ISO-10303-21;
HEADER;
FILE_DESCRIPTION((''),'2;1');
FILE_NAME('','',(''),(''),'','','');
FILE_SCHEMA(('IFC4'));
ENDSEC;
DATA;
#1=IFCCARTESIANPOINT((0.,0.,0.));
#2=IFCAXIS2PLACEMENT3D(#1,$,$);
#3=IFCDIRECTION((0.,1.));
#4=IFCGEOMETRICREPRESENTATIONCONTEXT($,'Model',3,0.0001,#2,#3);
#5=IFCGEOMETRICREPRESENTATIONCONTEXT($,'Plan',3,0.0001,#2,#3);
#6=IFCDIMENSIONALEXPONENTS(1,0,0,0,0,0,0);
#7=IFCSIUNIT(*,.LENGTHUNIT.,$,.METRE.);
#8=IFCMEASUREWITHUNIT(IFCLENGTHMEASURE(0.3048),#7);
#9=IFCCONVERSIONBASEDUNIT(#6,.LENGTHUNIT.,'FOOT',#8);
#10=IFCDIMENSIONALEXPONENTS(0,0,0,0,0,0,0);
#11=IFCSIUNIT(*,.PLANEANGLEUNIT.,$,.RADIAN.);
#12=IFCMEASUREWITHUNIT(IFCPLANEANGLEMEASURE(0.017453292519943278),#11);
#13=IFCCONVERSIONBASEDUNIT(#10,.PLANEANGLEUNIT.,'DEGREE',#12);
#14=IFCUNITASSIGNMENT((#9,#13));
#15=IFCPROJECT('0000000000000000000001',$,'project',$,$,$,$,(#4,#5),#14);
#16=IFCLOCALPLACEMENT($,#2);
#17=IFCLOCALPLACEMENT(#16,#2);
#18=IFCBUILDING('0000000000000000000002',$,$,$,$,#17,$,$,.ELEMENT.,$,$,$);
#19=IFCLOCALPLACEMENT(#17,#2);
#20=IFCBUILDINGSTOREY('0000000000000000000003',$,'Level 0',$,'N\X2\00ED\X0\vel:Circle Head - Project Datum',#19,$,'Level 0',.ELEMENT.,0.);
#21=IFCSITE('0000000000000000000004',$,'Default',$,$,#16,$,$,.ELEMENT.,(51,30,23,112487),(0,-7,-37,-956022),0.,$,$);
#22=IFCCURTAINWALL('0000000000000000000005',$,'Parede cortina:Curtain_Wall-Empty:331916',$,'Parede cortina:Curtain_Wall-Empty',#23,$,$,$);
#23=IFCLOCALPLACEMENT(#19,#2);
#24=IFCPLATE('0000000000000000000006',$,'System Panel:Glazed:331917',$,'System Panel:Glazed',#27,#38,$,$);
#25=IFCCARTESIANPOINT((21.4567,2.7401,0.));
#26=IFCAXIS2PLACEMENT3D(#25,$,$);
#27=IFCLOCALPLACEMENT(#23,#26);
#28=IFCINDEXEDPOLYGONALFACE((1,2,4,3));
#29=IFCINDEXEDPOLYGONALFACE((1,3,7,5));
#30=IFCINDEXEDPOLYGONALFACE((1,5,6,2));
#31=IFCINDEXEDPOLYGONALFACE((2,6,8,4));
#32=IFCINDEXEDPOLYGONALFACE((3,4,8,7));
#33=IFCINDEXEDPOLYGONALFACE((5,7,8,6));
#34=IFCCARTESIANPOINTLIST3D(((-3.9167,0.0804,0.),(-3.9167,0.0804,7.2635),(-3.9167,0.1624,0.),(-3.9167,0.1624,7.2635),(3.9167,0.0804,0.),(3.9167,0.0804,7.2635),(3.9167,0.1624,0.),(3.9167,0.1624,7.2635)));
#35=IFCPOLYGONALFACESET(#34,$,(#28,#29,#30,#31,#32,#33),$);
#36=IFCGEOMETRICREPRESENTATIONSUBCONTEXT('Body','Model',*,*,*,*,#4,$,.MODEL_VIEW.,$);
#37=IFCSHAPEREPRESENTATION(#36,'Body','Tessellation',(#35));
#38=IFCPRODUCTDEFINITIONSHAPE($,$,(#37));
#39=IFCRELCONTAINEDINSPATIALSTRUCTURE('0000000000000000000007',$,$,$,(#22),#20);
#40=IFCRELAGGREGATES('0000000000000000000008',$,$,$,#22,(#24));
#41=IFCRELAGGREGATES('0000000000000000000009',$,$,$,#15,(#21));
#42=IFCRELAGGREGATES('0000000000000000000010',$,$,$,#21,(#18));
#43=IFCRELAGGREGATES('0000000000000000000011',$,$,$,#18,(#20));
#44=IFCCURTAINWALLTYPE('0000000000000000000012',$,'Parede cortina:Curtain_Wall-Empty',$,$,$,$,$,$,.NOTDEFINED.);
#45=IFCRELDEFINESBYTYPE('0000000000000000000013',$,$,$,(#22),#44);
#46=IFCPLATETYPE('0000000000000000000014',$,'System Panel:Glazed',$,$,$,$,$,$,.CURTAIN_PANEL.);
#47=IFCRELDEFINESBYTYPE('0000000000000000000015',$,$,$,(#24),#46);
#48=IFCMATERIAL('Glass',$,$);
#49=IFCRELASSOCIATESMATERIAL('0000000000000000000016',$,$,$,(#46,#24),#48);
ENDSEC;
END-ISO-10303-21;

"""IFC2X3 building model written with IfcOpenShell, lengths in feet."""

from ifc_helpers import new_model, entity, si_unit, converted_unit, direction, frame, origin, origin_2d_with_axis, place, context, subcontext, project, spatial, rectangle, extrude, source, transform, mapped, material, type_object, type_shapes, element, aggregate, save


model = new_model("IFC2X3")

# Units and contexts
model_context = context("Model", 3, precision=0.0001, world=origin(), true_north=direction((0.0, 1.0)))
plan_context = context("Plan", 3, precision=0.0001, world=origin(), true_north=direction((0.0, 1.0)))
body_context = subcontext(model_context, "Body", "Model", "MODEL_VIEW")
ifc_project = project(units=[converted_unit("LENGTHUNIT", "FOOT", entity("IfcLengthMeasure", 0.3048), si_unit("LENGTHUNIT", "METRE"), dimensions=[1, 0, 0, 0, 0, 0, 0]), converted_unit("PLANEANGLEUNIT", "DEGREE", entity("IfcPlaneAngleMeasure", 0.017453292519943278), si_unit("PLANEANGLEUNIT", "RADIAN"), dimensions=[0, 0, 0, 0, 0, 0, 0])], contexts=[model_context, plan_context])

# Site, building, storey
site_placement = place(None, origin())
site = spatial("IfcSite", under=ifc_project, at=site_placement, Name="Default", CompositionType="ELEMENT", RefLatitude=(51, 30, 23, 112487), RefLongitude=(0, -7, -37, -956022), RefElevation=0.0)
building_placement = place(site_placement, origin())
building = spatial("IfcBuilding", under=site, at=building_placement, CompositionType="ELEMENT")
storey_placement = place(building_placement, origin())
storey = spatial("IfcBuildingStorey", under=building, at=storey_placement, Name="Level 0", ObjectType="Nível:Circle Head - Project Datum", LongName="Level 0", CompositionType="ELEMENT", Elevation=0.0)

# Curtain wall, plate
curtain_wall_type = type_object("IfcCurtainWallType", Name="Parede cortina:Curtain_Wall-Empty", PredefinedType="NOTDEFINED")
curtain_wall_placement = place(storey_placement, origin())
curtain_wall = element("IfcCurtainWall", 1, at=curtain_wall_placement, inside=storey, type_object=curtain_wall_type, Name="Parede cortina:Curtain_Wall-Empty:331916", ObjectType="Parede cortina:Curtain_Wall-Empty")
ifc_material_1 = material(Name="Glass")
plate_type = type_object("IfcPlateType", Name="System Panel:Glazed", PredefinedType="CURTAIN_PANEL", material=ifc_material_1)
shared_shape = source(origin(), body_context, "Body", "SweptSolid", [
    extrude(rectangle(XDim=0.082, YDim=7.8333, at=origin_2d_with_axis()), frame((0.0, 0.1214, 0.0), z_axis=(0.0, 0.0, 1.0), x_axis=(0.0, 1.0, 0.0)), (0.0, 0.0, 1.0), 7.2635),
])
type_shapes(plate_type, [shared_shape])
plate_placement = place(curtain_wall_placement, frame((21.4567, 2.7401, 0.0)))
plate = element("IfcPlate", 2, at=plate_placement, type_object=plate_type, material=ifc_material_1, Name="System Panel:Glazed:331917", ObjectType="System Panel:Glazed", context=body_context, shape_type="MappedRepresentation", body=[
    mapped(shared_shape, transform((0.0, 0.0, 0.0), scale=1.0)),
])
aggregate(curtain_wall, [plate])

save(model, "model.ifc")
